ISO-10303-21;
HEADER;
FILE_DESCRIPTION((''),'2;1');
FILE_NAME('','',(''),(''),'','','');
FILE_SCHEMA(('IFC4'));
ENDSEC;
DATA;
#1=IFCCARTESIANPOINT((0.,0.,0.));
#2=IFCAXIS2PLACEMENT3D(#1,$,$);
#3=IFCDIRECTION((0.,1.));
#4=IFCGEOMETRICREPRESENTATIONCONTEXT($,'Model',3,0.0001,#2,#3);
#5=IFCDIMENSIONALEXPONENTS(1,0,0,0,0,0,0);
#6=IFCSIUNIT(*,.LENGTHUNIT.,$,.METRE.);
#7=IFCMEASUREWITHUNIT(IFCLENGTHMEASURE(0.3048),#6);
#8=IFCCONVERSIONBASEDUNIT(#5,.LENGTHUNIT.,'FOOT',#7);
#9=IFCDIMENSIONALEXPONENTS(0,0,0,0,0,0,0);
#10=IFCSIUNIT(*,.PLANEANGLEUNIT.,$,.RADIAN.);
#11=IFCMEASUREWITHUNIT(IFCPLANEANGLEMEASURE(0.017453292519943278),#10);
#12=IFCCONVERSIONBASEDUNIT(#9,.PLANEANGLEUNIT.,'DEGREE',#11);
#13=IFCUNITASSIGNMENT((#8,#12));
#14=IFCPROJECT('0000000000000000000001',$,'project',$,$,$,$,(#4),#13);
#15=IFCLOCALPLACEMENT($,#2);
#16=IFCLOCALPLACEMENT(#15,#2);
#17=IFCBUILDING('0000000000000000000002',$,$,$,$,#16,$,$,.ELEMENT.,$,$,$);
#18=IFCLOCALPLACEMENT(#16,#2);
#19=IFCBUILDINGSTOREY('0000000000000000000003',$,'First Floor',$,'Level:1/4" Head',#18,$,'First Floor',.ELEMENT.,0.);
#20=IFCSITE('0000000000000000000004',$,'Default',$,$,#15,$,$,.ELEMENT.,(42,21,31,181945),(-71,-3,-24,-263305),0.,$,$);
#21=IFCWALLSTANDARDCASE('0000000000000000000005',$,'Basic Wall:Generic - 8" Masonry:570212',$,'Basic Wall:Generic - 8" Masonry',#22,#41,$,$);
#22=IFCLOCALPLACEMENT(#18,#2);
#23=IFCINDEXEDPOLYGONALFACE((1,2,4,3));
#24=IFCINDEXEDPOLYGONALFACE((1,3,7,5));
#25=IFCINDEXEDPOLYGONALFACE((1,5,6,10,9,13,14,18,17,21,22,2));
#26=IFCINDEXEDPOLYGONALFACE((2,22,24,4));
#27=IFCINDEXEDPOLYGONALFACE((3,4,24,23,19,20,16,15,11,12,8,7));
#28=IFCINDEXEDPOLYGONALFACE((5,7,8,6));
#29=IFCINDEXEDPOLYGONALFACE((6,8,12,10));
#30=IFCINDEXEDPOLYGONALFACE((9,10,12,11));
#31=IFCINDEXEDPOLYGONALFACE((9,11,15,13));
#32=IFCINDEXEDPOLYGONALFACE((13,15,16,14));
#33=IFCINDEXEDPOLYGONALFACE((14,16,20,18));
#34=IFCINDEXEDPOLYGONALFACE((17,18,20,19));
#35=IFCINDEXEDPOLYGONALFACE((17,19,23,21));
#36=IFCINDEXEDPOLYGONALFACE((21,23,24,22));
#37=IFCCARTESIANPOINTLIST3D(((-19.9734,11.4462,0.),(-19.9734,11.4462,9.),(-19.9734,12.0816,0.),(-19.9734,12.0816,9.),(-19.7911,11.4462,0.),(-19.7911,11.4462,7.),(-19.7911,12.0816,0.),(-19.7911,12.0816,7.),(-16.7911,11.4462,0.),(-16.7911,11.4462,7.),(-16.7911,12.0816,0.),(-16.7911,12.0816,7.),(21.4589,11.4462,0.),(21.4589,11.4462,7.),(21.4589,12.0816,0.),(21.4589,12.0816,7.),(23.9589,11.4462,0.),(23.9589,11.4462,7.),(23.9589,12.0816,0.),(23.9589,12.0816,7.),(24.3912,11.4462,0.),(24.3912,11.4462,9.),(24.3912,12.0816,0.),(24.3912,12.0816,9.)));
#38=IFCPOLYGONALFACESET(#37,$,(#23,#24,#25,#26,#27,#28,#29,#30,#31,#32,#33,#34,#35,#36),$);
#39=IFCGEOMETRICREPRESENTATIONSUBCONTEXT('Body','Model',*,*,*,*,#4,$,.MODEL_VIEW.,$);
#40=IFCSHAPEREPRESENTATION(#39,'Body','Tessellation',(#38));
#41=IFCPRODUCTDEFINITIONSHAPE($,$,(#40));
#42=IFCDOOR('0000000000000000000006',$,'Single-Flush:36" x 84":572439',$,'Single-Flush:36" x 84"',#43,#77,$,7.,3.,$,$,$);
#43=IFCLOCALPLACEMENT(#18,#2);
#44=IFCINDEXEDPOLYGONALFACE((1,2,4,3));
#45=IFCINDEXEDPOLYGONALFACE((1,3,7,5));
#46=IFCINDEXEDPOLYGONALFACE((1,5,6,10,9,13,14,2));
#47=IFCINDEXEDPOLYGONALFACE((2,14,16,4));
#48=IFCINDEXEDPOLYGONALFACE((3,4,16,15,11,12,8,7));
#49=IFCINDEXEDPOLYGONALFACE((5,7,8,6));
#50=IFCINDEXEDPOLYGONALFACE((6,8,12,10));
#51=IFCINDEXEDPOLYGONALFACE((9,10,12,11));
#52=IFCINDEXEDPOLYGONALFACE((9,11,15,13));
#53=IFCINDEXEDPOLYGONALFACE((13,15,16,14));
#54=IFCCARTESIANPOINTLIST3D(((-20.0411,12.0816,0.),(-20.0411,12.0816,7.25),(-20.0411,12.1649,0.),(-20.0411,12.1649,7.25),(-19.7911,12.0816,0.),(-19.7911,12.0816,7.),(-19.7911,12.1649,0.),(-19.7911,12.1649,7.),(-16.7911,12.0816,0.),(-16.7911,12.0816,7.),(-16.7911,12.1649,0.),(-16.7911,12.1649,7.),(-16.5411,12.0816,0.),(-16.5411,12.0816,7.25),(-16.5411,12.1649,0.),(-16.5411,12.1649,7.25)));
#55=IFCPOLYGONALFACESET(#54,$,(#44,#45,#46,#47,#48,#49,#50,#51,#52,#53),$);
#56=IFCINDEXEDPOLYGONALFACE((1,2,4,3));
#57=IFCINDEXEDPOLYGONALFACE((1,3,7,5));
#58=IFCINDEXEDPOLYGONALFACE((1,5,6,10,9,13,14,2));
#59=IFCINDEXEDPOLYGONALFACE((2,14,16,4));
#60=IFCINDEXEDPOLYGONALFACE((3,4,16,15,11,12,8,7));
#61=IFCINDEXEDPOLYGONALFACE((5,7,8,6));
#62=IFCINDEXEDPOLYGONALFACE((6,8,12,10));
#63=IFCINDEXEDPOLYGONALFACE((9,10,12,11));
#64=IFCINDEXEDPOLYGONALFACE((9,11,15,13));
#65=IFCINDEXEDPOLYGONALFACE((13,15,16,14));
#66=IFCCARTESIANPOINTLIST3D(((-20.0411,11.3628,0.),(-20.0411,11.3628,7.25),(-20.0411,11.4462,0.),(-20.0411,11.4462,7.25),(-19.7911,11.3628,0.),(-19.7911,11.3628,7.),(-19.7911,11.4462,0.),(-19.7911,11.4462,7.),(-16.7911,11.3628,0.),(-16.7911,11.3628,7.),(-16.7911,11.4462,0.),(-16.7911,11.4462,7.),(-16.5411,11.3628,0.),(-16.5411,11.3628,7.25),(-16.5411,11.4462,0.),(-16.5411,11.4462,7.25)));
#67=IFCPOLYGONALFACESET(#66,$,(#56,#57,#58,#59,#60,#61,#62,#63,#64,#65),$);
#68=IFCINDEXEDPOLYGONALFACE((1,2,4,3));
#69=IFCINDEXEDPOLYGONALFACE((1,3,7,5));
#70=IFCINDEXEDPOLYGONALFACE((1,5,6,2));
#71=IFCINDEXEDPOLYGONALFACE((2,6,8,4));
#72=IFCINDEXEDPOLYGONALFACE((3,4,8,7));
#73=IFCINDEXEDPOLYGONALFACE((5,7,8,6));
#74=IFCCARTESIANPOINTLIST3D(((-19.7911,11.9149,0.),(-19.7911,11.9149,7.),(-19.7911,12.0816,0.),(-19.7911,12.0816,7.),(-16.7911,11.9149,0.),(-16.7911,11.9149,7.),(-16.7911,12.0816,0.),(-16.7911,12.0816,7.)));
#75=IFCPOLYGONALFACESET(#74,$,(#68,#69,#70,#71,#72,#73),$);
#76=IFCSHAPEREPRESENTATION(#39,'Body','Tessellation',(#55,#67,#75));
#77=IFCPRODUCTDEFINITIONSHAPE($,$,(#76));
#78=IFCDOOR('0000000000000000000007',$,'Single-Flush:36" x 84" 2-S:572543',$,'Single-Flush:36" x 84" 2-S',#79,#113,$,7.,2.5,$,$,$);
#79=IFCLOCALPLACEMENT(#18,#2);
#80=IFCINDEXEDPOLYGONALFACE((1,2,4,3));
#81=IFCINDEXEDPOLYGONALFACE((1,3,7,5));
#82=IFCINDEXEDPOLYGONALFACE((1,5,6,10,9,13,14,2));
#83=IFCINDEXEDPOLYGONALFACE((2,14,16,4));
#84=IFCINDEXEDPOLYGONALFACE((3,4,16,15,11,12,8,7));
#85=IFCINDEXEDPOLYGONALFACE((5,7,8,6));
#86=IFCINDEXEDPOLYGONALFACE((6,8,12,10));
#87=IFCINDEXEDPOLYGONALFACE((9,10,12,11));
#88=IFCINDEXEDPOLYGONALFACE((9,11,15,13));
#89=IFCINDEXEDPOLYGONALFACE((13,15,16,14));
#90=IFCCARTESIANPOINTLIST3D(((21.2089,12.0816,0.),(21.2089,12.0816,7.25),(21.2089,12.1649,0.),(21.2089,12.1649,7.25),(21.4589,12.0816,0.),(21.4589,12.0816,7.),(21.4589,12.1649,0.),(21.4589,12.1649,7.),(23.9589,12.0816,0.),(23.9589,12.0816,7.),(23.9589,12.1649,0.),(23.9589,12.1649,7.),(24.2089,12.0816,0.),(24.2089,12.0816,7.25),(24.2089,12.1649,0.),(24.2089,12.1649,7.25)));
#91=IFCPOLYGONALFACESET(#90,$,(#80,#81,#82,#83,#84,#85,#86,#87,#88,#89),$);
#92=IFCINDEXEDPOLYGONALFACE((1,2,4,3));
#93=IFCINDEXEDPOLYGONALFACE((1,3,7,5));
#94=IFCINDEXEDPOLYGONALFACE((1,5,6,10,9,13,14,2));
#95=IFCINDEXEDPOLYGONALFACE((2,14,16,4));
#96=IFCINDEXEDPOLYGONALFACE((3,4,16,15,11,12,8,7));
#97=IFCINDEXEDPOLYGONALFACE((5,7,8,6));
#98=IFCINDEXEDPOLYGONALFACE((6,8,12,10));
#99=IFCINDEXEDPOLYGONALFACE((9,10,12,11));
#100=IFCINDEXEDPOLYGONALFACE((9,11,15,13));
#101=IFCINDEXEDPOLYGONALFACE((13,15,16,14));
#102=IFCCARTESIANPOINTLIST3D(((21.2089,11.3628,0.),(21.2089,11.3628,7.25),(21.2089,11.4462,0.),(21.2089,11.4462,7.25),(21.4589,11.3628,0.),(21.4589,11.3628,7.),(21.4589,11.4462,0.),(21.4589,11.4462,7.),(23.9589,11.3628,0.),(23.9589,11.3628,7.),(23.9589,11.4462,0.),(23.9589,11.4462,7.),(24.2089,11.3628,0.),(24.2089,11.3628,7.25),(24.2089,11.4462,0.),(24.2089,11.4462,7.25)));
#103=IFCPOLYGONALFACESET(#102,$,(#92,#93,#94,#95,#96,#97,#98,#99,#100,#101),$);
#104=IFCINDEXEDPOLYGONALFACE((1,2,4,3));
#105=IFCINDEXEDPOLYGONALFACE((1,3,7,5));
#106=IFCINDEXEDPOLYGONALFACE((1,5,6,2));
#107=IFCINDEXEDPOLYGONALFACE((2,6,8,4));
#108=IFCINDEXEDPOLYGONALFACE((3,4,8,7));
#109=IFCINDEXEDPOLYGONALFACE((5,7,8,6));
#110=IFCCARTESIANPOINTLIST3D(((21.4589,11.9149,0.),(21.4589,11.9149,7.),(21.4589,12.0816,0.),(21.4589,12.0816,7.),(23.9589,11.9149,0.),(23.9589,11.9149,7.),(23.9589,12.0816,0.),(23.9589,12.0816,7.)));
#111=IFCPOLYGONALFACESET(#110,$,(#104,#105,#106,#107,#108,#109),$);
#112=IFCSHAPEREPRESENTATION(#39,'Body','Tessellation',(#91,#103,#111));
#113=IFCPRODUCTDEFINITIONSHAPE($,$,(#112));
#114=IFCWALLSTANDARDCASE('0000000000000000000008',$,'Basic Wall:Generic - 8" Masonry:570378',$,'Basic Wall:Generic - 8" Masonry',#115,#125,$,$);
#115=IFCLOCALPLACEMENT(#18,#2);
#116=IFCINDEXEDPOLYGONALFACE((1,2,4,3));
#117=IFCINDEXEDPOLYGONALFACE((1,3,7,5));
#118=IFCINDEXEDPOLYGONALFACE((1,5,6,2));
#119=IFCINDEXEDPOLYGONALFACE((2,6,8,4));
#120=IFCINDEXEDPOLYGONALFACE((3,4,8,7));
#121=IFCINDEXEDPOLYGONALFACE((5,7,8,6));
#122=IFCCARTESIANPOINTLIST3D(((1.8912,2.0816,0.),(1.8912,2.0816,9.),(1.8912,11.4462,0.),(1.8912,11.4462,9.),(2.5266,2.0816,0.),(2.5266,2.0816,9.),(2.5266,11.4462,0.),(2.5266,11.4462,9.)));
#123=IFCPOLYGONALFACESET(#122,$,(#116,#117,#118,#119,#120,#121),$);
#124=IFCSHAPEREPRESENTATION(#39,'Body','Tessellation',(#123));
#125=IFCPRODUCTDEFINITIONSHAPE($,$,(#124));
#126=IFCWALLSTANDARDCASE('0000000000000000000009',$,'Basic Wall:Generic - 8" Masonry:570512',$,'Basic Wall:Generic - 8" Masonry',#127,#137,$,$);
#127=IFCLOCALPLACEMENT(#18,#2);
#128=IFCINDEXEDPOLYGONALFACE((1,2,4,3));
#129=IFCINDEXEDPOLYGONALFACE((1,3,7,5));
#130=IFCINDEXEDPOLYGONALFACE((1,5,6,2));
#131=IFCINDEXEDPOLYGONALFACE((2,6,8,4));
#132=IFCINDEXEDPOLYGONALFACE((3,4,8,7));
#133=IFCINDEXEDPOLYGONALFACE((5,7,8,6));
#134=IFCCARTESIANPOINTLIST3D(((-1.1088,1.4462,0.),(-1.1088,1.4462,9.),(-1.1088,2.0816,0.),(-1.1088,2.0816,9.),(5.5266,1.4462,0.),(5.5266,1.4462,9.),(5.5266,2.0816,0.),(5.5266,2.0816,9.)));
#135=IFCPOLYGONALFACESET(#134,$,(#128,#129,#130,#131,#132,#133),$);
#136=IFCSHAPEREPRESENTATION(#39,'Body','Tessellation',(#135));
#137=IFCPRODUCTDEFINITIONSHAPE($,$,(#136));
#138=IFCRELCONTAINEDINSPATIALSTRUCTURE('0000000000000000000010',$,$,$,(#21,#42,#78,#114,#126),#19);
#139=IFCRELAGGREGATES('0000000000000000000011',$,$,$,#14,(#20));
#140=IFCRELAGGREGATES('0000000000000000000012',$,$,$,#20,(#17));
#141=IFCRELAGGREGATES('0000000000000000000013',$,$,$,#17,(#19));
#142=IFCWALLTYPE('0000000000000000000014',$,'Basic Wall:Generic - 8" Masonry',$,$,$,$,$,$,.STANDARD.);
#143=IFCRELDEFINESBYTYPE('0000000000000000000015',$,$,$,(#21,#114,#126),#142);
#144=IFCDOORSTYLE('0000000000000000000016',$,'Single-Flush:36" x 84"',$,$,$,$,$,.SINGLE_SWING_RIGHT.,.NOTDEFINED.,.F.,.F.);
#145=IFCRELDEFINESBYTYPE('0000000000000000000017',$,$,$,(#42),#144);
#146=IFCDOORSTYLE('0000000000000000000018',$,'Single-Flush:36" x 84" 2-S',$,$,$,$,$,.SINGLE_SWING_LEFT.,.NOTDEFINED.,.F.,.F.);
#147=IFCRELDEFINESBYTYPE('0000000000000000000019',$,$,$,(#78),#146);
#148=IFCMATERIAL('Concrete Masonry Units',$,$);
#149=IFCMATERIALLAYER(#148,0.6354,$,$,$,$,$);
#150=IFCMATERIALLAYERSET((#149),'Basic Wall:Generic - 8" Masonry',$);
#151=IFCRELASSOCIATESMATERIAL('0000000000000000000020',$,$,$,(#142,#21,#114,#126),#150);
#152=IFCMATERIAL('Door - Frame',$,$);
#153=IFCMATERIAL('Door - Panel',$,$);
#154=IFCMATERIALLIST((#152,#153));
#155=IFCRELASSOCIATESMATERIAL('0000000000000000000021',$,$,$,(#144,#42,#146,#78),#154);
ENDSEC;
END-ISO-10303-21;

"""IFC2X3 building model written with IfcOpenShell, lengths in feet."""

from ifc_helpers import new_model, entity, si_unit, converted_unit, direction, frame, frame_2d, origin, place, context, subcontext, project, spatial, polyline, rectangle, outline, extrude, source, transform, mapped, material, material_list, layer, layer_set, layer_usage, type_object, type_shapes, element, fill, save


model = new_model("IFC2X3")

# Units and contexts
model_context = context("Model", 3, precision=0.0001, world=origin(), true_north=direction((0.0, 1.0)))
body_context = subcontext(model_context, "Body", "Model", "MODEL_VIEW")
ifc_project = project(units=[converted_unit("LENGTHUNIT", "FOOT", entity("IfcLengthMeasure", 0.3048), si_unit("LENGTHUNIT", "METRE"), dimensions=[1, 0, 0, 0, 0, 0, 0]), converted_unit("PLANEANGLEUNIT", "DEGREE", entity("IfcPlaneAngleMeasure", 0.017453292519943278), si_unit("PLANEANGLEUNIT", "RADIAN"), dimensions=[0, 0, 0, 0, 0, 0, 0])], contexts=[model_context])

# Site, building, storey
site_placement = place(None, origin())
site = spatial("IfcSite", under=ifc_project, at=site_placement, Name="Default", CompositionType="ELEMENT", RefLatitude=(42, 21, 31, 181945), RefLongitude=(-71, -3, -24, -263305), RefElevation=0.0)
building_placement = place(site_placement, origin())
building = spatial("IfcBuilding", under=site, at=building_placement, CompositionType="ELEMENT")
storey_placement = place(building_placement, origin())
storey = spatial("IfcBuildingStorey", under=building, at=storey_placement, Name="First Floor", ObjectType="Level:1/4\" Head", LongName="First Floor", CompositionType="ELEMENT", Elevation=0.0)

# Shared definitions
ifc_material_1 = material(Name="Concrete Masonry Units")
ifc_layer_1 = layer(ifc_material_1, 0.6354)
ifc_layer_set_1 = layer_set([ifc_layer_1], Name="Basic Wall:Generic - 8\" Masonry")
wall_type = type_object("IfcWallType", Name="Basic Wall:Generic - 8\" Masonry", PredefinedType="STANDARD", material=ifc_layer_set_1)

# Wall, openings, doors
ifc_layer_usage_1 = layer_usage(ifc_layer_set_1, "AXIS2", "NEGATIVE", 0.3177)
wall_1_placement = place(storey_placement, frame((-19.9734, 11.7639, 0.0)))
wall_1 = element("IfcWallStandardCase", 1, at=wall_1_placement, inside=storey, type_object=wall_type, material=ifc_layer_usage_1, Name="Basic Wall:Generic - 8\" Masonry:570212", ObjectType="Basic Wall:Generic - 8\" Masonry", context=body_context, shape_type="SweptSolid", body=[
    extrude(rectangle(XDim=44.3646, YDim=0.6354, at=frame_2d((22.1823, 0.0), x_axis=(-1.0, 0.0))), origin(), (0.0, 0.0, 1.0), 9.0),
])
opening_1_placement = place(wall_1_placement, frame((0.1823, -0.3177, 0.0)))
opening_1 = element("IfcOpeningElement", 2, at=opening_1_placement, cuts=wall_1, ObjectType="Opening", context=body_context, shape_type="SweptSolid", body=[
    extrude(rectangle(XDim=3.0, YDim=7.0, at=frame_2d((3.5, 1.5), x_axis=(0.0, 1.0))), frame((0.0, 0.0, 0.0), z_axis=(0.0, 1.0, 0.0), x_axis=(0.0, 0.0, 1.0)), (0.0, 0.0, 1.0), 0.6354),
])
opening_2_placement = place(wall_1_placement, frame((41.4323, -0.3177, 0.0)))
opening_2 = element("IfcOpeningElement", 3, at=opening_2_placement, cuts=wall_1, ObjectType="Opening", context=body_context, shape_type="SweptSolid", body=[
    extrude(rectangle(XDim=2.5, YDim=7.0, at=frame_2d((3.5, 1.25), x_axis=(0.0, -1.0))), frame((0.0, 0.0, 0.0), z_axis=(0.0, 1.0, 0.0), x_axis=(0.0, 0.0, 1.0)), (0.0, 0.0, 1.0), 0.6354),
])
ifc_material_2 = material(Name="Door - Frame")
ifc_material_3 = material(Name="Door - Panel")
ifc_material_list_1 = material_list([ifc_material_2, ifc_material_3])
door_style_1 = type_object("IfcDoorStyle", Name="Single-Flush:36\" x 84\"", ConstructionType="NOTDEFINED", OperationType="SINGLE_SWING_RIGHT", ParameterTakesPrecedence=False, Sizeable=False, material=ifc_material_list_1)
shared_shape_1 = source(origin(), body_context, "Body", "SweptSolid", [
    extrude(outline(polyline([(-1.75, -3.6875), (1.75, -3.6875), (1.75, 3.5625), (1.5, 3.5625), (1.5, -3.4375), (-1.5, -3.4375), (-1.5, 3.5625), (-1.75, 3.5625), (-1.75, -3.6875)])), frame((1.5, 0.6354, 3.5625), z_axis=(0.0, 1.0, 0.0), x_axis=(1.0, 0.0, 0.0)), (0.0, 0.0, 1.0), 0.0833),
    extrude(outline(polyline([(-3.6875, -1.75), (3.5625, -1.75), (3.5625, -1.5), (-3.4375, -1.5), (-3.4375, 1.5), (3.5625, 1.5), (3.5625, 1.75), (-3.6875, 1.75), (-3.6875, -1.75)])), frame((1.5, -0.0833, 3.5625), z_axis=(0.0, 1.0, 0.0), x_axis=(0.0, 0.0, -1.0)), (0.0, 0.0, 1.0), 0.0833),
    extrude(rectangle(XDim=0.1667, YDim=3.0, at=frame_2d((0.0, 0.0), x_axis=(1.0, 0.0))), frame((1.5, 0.5521, 0.0), z_axis=(0.0, 0.0, 1.0), x_axis=(0.0, 1.0, 0.0)), (0.0, 0.0, 1.0), 7.0),
])
type_shapes(door_style_1, [shared_shape_1])
door_1_placement = place(opening_1_placement, origin())
door_1 = element("IfcDoor", 4, at=door_1_placement, inside=storey, type_object=door_style_1, material=ifc_material_list_1, Name="Single-Flush:36\" x 84\":572439", ObjectType="Single-Flush:36\" x 84\"", OverallHeight=7.0, OverallWidth=3.0, context=body_context, shape_type="MappedRepresentation", body=[
    mapped(shared_shape_1, transform((0.0, 0.0, 0.0), scale=1.0)),
])
fill(opening_1, door_1)
door_style_2 = type_object("IfcDoorStyle", Name="Single-Flush:36\" x 84\" 2-S", ConstructionType="NOTDEFINED", OperationType="SINGLE_SWING_LEFT", ParameterTakesPrecedence=False, Sizeable=False, material=ifc_material_list_1)
shared_shape_2 = source(origin(), body_context, "Body", "SweptSolid", [
    extrude(outline(polyline([(-1.5, -3.6875), (1.5, -3.6875), (1.5, 3.5625), (1.25, 3.5625), (1.25, -3.4375), (-1.25, -3.4375), (-1.25, 3.5625), (-1.5, 3.5625), (-1.5, -3.6875)])), frame((1.25, 0.7187, 3.5625), z_axis=(0.0, -1.0, 0.0), x_axis=(-1.0, 0.0, 0.0)), (0.0, 0.0, 1.0), 0.0833),
    extrude(outline(polyline([(-3.6875, -1.5), (3.5625, -1.5), (3.5625, -1.25), (-3.4375, -1.25), (-3.4375, 1.25), (3.5625, 1.25), (3.5625, 1.5), (-3.6875, 1.5), (-3.6875, -1.5)])), frame((1.25, 0.0, 3.5625), z_axis=(0.0, -1.0, 0.0), x_axis=(0.0, 0.0, -1.0)), (0.0, 0.0, 1.0), 0.0833),
    extrude(rectangle(XDim=2.5, YDim=0.1667, at=frame_2d((0.0, 0.0), x_axis=(1.0, 0.0))), frame((1.25, 0.5521, 0.0)), (0.0, 0.0, 1.0), 7.0),
])
type_shapes(door_style_2, [shared_shape_2])
door_2_placement = place(opening_2_placement, origin())
door_2 = element("IfcDoor", 5, at=door_2_placement, inside=storey, type_object=door_style_2, material=ifc_material_list_1, Name="Single-Flush:36\" x 84\" 2-S:572543", ObjectType="Single-Flush:36\" x 84\" 2-S", OverallHeight=7.0, OverallWidth=2.5, context=body_context, shape_type="MappedRepresentation", body=[
    mapped(shared_shape_2, transform((0.0, 0.0, 0.0), scale=1.0)),
])
fill(opening_2, door_2)

# Walls
ifc_layer_usage_2 = layer_usage(ifc_layer_set_1, "AXIS2", "NEGATIVE", 0.3177)
wall_2_placement = place(storey_placement, frame((2.2089, 11.4462, 0.0), z_axis=(0.0, 0.0, 1.0), x_axis=(0.0, -1.0, 0.0)))
element("IfcWallStandardCase", 6, at=wall_2_placement, inside=storey, type_object=wall_type, material=ifc_layer_usage_2, Name="Basic Wall:Generic - 8\" Masonry:570378", ObjectType="Basic Wall:Generic - 8\" Masonry", context=body_context, shape_type="SweptSolid", body=[
    extrude(rectangle(XDim=9.3646, YDim=0.6354, at=frame_2d((4.6823, 0.0), x_axis=(-1.0, 0.0))), origin(), (0.0, 0.0, 1.0), 9.0),
])
ifc_layer_usage_3 = layer_usage(ifc_layer_set_1, "AXIS2", "NEGATIVE", 0.3177)
wall_3_placement = place(storey_placement, frame((-1.1088, 1.7639, 0.0)))
element("IfcWallStandardCase", 7, at=wall_3_placement, inside=storey, type_object=wall_type, material=ifc_layer_usage_3, Name="Basic Wall:Generic - 8\" Masonry:570512", ObjectType="Basic Wall:Generic - 8\" Masonry", context=body_context, shape_type="SweptSolid", body=[
    extrude(rectangle(XDim=6.6354, YDim=0.6354, at=frame_2d((3.3177, 0.0), x_axis=(-1.0, 0.0))), origin(), (0.0, 0.0, 1.0), 9.0),
])

save(model, "model.ifc")
